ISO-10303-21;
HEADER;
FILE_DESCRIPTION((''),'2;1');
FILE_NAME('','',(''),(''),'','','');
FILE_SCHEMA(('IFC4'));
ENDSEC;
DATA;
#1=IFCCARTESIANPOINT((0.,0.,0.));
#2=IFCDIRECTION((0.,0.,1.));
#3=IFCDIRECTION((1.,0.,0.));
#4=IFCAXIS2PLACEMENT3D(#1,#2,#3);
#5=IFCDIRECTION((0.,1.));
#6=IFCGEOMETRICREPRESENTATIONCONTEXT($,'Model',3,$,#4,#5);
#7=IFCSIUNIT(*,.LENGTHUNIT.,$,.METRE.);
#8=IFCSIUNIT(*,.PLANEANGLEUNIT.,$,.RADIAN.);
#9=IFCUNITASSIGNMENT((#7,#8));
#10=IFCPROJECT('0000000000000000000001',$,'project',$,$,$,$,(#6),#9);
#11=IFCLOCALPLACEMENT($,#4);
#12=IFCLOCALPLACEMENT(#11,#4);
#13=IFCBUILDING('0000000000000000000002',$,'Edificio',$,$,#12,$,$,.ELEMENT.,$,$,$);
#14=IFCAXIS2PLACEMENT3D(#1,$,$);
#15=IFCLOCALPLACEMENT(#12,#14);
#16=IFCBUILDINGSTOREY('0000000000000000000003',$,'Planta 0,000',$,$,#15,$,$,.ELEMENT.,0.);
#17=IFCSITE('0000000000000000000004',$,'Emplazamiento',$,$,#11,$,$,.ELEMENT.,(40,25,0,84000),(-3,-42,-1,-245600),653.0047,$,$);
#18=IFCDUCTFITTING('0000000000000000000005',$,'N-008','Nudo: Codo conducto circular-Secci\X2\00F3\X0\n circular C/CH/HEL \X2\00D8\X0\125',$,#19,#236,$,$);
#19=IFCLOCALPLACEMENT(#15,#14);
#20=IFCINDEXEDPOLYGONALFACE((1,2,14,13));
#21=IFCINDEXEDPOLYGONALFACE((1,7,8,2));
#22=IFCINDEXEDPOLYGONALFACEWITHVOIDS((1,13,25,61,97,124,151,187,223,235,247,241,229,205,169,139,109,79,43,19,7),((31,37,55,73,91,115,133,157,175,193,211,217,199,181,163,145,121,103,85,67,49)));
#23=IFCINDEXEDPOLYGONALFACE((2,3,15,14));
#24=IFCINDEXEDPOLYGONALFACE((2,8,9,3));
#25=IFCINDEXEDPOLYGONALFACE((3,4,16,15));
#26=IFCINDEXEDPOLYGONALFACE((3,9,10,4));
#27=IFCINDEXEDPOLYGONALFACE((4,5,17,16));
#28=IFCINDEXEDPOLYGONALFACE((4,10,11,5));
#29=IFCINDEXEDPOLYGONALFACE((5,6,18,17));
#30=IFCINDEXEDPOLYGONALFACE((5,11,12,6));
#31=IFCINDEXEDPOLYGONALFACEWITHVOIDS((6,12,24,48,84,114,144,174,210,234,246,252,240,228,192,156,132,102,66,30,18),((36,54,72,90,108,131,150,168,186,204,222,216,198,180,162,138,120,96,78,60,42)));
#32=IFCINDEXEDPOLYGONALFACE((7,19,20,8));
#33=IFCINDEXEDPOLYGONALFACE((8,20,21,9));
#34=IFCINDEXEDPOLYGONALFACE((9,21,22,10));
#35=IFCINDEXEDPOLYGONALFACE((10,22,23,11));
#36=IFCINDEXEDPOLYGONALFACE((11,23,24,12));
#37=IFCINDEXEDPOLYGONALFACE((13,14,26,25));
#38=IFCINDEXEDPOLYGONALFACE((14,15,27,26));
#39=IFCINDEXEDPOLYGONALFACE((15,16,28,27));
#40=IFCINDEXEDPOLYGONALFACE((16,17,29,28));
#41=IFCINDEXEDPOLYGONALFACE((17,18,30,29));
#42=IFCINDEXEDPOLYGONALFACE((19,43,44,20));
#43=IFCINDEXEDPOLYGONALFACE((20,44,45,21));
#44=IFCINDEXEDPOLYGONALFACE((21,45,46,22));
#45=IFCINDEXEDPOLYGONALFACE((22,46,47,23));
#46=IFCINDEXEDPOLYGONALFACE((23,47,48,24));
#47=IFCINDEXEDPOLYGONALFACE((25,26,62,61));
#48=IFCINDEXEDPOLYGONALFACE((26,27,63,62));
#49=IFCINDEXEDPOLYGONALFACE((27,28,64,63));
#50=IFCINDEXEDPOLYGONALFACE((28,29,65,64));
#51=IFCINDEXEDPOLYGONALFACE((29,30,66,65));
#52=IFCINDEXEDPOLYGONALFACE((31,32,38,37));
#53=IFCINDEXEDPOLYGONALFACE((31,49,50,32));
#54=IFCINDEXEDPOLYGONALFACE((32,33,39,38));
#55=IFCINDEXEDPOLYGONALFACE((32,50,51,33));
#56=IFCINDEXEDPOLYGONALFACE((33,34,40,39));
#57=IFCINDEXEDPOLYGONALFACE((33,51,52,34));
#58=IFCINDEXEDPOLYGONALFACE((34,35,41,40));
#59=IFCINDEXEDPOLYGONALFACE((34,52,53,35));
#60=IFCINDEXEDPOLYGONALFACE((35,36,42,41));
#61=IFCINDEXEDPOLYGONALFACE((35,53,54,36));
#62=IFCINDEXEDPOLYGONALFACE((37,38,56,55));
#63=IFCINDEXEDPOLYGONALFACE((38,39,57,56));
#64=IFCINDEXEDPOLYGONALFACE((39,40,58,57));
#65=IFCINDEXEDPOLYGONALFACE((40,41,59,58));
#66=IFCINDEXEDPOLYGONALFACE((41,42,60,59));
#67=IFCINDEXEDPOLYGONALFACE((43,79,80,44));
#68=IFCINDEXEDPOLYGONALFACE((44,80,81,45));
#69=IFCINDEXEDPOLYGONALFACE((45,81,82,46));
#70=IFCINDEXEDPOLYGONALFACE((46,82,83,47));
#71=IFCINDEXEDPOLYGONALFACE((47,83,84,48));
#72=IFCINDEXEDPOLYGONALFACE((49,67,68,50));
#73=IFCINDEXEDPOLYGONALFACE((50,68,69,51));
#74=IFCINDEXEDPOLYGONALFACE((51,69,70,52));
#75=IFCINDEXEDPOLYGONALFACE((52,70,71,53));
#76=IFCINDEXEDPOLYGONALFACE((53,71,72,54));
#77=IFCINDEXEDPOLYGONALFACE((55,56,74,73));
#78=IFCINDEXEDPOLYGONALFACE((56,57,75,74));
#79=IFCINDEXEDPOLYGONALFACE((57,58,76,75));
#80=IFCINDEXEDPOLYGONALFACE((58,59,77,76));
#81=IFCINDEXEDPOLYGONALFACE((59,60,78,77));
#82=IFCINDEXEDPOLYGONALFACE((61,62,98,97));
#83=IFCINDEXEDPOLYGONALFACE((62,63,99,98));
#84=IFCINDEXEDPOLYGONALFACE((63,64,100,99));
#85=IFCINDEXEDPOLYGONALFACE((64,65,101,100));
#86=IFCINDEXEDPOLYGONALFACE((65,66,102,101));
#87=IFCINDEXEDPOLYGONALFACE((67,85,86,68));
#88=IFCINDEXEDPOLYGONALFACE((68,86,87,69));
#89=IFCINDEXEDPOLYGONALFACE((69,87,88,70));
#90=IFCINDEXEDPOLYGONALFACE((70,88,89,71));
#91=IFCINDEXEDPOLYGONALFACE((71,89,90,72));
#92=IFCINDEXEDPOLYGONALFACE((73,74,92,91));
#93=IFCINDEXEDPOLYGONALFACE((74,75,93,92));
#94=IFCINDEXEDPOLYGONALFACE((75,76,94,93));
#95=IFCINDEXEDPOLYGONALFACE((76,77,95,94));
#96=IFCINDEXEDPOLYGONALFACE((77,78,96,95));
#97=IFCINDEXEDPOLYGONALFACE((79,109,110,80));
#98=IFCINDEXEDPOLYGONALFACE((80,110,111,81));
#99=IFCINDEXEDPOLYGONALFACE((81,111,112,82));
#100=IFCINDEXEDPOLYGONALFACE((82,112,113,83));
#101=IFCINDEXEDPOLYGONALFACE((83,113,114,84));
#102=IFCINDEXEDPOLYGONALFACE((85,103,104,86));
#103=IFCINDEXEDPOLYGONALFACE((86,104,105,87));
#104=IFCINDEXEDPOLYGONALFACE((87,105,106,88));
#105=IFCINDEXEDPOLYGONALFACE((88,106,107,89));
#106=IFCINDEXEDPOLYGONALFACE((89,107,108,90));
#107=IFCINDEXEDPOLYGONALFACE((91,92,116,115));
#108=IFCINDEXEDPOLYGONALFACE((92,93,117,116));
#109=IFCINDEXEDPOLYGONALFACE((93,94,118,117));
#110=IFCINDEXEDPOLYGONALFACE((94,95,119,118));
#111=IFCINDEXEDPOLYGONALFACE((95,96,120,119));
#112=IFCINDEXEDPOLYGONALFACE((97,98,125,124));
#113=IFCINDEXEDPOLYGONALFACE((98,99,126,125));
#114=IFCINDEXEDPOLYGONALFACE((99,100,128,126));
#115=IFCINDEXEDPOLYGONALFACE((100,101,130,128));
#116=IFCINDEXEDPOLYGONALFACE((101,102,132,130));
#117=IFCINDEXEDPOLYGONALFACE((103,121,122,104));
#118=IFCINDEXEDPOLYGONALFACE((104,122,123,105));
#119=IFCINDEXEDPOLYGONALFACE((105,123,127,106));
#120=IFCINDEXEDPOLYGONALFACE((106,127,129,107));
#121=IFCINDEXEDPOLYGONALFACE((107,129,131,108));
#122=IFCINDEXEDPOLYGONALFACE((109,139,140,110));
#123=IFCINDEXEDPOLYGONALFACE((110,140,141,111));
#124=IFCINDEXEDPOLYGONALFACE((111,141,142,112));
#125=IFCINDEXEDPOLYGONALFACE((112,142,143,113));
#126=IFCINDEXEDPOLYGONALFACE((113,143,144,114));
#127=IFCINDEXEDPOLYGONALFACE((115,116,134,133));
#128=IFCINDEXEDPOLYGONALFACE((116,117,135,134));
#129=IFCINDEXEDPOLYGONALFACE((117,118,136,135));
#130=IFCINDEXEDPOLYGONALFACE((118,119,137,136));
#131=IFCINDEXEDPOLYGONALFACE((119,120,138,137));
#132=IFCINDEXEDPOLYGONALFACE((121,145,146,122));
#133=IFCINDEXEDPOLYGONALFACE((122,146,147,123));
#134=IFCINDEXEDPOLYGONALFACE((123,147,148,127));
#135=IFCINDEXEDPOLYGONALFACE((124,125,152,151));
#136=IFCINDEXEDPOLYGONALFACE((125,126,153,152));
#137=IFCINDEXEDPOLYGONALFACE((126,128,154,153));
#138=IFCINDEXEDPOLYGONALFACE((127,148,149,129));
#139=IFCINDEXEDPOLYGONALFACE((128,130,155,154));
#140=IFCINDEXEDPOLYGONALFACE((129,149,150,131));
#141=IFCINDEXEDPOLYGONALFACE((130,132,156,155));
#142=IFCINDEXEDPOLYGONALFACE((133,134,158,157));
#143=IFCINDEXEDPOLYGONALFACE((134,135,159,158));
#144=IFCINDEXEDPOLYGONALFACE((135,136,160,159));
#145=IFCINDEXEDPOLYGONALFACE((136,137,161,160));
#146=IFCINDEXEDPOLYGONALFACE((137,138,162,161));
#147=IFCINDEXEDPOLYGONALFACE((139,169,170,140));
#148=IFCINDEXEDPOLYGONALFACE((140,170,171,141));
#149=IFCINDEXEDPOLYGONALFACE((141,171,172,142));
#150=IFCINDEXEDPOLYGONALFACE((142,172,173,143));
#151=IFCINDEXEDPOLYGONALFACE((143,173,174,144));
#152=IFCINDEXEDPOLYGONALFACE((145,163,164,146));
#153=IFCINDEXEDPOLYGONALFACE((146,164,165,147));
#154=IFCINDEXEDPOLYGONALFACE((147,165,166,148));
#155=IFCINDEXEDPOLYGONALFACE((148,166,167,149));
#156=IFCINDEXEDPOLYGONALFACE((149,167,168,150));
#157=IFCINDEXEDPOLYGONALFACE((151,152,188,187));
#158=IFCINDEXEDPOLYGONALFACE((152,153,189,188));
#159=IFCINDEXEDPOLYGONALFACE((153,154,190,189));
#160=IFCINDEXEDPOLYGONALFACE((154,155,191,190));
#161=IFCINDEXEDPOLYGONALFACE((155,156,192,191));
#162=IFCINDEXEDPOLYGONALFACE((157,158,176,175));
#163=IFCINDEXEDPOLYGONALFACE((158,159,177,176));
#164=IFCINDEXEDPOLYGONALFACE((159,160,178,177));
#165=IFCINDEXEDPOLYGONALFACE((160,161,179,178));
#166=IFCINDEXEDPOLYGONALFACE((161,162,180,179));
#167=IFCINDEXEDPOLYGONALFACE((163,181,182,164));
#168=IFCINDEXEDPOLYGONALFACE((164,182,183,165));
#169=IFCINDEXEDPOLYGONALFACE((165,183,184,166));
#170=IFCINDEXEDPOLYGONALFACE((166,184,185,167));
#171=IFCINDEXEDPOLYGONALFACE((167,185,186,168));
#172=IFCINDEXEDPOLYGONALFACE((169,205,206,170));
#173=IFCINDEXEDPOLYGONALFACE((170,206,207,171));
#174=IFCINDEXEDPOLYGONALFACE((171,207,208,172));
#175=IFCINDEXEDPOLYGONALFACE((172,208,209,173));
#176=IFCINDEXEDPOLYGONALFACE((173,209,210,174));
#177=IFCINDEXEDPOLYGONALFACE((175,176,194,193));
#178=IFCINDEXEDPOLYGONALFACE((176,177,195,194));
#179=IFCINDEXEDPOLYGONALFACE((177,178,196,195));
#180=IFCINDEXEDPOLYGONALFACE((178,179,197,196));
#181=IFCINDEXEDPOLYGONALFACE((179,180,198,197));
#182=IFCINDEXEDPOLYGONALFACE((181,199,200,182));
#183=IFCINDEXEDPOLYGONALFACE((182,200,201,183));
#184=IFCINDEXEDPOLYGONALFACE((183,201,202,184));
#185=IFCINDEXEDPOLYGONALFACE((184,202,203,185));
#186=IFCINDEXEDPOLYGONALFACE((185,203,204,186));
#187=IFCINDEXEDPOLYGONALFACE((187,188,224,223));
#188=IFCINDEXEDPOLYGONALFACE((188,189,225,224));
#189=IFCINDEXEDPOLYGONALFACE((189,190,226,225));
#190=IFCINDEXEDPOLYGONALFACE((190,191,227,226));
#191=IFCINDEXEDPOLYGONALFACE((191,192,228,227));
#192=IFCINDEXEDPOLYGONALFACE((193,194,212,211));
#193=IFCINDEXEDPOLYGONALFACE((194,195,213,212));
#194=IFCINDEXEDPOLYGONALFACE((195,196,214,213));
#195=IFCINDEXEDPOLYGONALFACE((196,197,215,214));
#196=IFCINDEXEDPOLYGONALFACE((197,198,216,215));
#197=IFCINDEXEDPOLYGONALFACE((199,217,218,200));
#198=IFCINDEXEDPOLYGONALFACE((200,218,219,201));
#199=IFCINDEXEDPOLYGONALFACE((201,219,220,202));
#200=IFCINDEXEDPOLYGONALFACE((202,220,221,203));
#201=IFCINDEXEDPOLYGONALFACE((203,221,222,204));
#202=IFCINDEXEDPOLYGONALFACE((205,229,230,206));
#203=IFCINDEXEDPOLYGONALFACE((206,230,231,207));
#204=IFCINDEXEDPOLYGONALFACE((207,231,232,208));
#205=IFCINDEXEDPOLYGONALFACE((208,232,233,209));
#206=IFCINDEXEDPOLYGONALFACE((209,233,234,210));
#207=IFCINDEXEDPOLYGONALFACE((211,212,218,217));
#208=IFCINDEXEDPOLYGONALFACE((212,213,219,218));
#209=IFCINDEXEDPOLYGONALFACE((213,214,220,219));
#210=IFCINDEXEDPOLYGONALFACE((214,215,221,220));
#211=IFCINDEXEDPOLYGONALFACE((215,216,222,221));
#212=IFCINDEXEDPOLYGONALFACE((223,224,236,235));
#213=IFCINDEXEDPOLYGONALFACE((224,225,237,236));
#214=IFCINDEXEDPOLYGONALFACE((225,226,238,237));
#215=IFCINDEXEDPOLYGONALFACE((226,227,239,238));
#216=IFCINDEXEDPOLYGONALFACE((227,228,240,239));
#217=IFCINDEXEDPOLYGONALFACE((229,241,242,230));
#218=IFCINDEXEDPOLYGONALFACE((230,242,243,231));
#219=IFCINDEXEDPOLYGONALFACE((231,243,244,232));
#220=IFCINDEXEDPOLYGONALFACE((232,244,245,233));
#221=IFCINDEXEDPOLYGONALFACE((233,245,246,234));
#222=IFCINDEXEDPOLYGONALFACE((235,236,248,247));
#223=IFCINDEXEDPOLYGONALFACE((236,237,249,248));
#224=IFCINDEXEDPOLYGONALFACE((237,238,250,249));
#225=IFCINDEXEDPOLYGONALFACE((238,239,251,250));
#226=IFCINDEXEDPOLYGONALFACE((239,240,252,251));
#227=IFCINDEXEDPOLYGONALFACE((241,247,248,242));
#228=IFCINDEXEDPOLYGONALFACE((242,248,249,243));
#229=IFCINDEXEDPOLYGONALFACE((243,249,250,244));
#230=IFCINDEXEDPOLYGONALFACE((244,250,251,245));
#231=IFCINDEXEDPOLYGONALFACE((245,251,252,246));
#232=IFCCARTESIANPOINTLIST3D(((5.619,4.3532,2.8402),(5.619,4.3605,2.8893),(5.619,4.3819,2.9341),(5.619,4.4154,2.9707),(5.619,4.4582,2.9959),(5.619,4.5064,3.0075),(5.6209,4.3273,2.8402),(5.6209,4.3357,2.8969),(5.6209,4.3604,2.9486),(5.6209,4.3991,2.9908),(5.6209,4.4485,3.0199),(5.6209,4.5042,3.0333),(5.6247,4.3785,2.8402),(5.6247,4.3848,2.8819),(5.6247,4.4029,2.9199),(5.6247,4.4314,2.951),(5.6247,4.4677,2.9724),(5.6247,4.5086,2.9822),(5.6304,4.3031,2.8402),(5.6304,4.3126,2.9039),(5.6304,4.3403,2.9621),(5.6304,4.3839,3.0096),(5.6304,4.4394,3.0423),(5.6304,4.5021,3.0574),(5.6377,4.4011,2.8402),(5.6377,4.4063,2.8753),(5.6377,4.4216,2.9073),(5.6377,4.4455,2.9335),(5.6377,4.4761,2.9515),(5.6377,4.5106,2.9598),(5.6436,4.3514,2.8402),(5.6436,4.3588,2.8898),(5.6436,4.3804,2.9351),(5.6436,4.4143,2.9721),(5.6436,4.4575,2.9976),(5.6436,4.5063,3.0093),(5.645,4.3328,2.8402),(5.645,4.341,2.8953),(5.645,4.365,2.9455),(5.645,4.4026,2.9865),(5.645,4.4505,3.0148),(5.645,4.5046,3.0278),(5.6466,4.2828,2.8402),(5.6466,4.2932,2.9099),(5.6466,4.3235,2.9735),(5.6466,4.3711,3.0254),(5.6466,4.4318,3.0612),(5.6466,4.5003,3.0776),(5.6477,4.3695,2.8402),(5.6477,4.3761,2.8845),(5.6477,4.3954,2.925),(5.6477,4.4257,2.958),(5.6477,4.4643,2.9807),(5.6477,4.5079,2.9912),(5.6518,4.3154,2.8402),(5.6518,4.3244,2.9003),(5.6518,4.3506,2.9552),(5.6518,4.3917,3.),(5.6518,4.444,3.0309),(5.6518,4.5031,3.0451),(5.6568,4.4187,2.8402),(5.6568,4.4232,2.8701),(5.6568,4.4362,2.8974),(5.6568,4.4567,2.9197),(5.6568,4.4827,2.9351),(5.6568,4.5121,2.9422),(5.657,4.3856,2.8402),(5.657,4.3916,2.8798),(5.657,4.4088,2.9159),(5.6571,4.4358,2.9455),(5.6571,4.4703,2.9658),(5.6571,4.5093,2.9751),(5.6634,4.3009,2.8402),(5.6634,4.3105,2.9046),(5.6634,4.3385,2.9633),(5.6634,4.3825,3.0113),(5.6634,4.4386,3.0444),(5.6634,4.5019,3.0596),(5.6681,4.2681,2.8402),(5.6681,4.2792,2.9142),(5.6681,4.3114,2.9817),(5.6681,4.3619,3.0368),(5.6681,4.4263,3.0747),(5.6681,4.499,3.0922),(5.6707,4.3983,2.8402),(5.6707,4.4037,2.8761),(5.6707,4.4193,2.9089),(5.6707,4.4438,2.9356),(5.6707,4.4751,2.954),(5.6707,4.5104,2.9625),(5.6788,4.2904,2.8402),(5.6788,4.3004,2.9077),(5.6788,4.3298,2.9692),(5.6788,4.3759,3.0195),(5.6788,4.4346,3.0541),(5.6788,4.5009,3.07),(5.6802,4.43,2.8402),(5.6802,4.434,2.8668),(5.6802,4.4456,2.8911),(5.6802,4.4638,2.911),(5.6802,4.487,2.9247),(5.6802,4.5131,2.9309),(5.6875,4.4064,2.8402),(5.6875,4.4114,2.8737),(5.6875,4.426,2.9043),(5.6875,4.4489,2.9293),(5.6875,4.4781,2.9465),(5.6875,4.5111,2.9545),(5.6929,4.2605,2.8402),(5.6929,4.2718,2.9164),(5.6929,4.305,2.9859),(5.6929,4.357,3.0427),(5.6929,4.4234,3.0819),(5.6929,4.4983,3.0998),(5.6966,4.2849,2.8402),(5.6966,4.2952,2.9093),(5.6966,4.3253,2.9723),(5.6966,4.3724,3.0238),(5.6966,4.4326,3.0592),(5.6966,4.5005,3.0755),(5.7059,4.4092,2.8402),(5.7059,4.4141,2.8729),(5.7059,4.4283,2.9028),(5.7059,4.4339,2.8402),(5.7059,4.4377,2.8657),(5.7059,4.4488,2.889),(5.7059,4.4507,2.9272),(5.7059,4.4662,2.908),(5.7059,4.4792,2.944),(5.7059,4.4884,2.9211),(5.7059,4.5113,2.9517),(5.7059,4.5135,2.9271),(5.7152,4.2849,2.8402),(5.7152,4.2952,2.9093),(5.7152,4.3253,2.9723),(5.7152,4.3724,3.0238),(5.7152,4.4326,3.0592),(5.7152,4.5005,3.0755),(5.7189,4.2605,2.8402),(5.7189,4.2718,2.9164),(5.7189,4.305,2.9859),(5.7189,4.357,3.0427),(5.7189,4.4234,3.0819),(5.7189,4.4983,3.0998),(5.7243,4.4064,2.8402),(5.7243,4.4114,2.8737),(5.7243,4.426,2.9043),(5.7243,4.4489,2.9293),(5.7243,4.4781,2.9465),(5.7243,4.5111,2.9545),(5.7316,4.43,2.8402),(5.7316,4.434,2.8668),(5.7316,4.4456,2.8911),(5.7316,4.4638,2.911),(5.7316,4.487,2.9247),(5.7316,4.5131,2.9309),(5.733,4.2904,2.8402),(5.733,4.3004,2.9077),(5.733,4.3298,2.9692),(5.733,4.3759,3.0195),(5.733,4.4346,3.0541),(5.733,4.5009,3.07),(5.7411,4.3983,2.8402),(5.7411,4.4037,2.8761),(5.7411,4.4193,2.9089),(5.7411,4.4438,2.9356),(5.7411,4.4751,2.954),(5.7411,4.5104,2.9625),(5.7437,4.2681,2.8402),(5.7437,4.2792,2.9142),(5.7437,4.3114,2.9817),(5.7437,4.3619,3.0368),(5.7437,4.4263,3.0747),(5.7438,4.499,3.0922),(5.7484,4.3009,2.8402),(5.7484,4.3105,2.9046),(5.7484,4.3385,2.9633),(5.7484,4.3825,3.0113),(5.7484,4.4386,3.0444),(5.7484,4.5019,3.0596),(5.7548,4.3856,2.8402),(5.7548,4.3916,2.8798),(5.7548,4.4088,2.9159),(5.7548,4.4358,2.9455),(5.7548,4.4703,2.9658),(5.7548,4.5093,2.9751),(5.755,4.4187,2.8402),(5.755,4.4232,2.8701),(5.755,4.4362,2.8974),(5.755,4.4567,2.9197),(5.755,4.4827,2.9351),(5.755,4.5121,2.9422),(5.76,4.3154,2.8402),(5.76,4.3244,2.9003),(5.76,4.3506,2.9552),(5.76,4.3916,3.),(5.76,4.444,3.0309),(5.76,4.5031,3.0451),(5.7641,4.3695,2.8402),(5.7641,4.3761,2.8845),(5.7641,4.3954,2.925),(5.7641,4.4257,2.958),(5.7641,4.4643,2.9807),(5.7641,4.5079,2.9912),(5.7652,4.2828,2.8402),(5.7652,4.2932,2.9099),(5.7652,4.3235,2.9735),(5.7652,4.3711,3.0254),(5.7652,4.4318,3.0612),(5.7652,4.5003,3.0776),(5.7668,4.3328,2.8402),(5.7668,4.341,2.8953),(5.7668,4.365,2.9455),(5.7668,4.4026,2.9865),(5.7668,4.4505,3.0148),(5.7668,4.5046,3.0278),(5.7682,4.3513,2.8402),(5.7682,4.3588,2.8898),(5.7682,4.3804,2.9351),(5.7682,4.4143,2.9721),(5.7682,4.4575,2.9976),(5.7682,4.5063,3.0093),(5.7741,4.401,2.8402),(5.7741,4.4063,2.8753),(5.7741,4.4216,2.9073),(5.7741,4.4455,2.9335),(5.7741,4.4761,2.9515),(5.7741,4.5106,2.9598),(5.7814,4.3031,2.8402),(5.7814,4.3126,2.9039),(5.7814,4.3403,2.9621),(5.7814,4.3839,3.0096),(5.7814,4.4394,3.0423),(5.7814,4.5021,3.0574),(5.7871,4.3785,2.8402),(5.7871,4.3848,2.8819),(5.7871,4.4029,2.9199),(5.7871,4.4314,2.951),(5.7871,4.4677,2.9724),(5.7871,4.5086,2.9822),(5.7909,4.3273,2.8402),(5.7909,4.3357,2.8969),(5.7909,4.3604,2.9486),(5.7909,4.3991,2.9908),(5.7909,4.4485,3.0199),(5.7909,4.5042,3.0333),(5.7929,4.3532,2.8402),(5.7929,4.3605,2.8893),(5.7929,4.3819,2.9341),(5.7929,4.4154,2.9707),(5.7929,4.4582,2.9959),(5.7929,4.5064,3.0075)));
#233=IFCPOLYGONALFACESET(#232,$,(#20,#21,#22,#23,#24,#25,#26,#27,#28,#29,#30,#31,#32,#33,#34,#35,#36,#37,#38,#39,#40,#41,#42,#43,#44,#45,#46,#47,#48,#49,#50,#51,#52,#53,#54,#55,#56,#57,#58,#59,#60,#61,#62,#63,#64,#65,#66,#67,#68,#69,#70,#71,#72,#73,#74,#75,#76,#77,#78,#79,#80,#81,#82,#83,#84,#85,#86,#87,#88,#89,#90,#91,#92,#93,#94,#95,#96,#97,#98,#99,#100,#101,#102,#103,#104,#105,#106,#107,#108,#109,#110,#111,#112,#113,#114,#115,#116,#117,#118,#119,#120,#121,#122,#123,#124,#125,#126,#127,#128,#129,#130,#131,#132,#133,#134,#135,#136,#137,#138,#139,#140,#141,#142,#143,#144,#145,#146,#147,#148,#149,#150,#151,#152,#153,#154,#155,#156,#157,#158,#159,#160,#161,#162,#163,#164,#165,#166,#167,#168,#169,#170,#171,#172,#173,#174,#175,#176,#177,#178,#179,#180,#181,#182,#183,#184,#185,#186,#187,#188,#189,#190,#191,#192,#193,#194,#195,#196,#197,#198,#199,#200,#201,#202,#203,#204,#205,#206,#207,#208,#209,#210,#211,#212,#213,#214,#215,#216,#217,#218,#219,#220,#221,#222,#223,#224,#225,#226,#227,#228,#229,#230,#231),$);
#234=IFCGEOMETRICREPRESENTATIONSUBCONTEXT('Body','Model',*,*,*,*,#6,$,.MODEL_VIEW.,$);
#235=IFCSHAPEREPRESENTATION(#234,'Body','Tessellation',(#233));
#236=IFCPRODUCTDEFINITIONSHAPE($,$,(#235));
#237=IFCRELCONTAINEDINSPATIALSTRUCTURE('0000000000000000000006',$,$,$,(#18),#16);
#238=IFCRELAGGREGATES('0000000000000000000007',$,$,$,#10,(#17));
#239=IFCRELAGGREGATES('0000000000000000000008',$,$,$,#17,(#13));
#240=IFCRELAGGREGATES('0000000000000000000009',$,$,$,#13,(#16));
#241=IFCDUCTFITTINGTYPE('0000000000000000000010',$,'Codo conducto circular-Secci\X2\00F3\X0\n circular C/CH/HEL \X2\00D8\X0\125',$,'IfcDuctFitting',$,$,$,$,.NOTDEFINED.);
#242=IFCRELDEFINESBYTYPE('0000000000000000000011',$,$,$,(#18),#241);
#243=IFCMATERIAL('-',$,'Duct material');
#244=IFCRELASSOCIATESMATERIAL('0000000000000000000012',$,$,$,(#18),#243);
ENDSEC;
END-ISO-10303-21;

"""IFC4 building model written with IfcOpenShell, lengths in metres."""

from ifc_helpers import new_model, entity, si_unit, direction, origin, origin_with_axes, place, context, subcontext, project, spatial, source, transform, mapped, material, type_object, element, save


model = new_model("IFC4")

# Units and contexts
model_context = context("Model", 3, world=origin_with_axes(), true_north=direction((0.0, 1.0)))
body_context = subcontext(model_context, "Body", "Model", "MODEL_VIEW")
ifc_project = project(units=[si_unit("LENGTHUNIT", "METRE"), si_unit("PLANEANGLEUNIT", "RADIAN")], contexts=[model_context])

# Site, building, storey
site_placement = place(None, origin_with_axes())
site = spatial("IfcSite", under=ifc_project, at=site_placement, Name="Emplazamiento", CompositionType="ELEMENT", RefLatitude=(40, 25, 0, 84000), RefLongitude=(-3, -42, -1, -245600), RefElevation=653.0047)
building_placement = place(site_placement, origin_with_axes())
building = spatial("IfcBuilding", under=site, at=building_placement, Name="Edificio", CompositionType="ELEMENT")
storey_placement = place(building_placement, origin())
storey = spatial("IfcBuildingStorey", under=building, at=storey_placement, Name="Planta 0,000", CompositionType="ELEMENT", Elevation=0.0)

# Shared definitions
ifc_material_1 = material(Name="-", Category="Duct material")
duct_fitting_type_1 = type_object("IfcDuctFittingType", Name="Codo conducto circular-Sección circular C/CH/HEL Ø125", ApplicableOccurrence="IfcDuctFitting", PredefinedType="NOTDEFINED")

# Duct fitting
shared_shape_1 = source(origin_with_axes(), body_context, "Body", "SweptSolid", [
    entity("IfcRevolvedAreaSolid", entity("IfcCircleHollowProfileDef", "AREA", None, entity("IfcAxis2Placement2D", entity("IfcCartesianPoint", [0.0, 0.0]), entity("IfcDirection", [1.0, 0.0])), 0.0872, 0.0247), entity("IfcAxis2Placement3D", entity("IfcCartesianPoint", [0.1592, 0.0139, 0.0]), entity("IfcDirection", [-0.996184, -0.087276, 0.0]), entity("IfcDirection", [0.087276, -0.996184, 0.0])), entity("IfcAxis1Placement", entity("IfcCartesianPoint", [0.1744, 0.0, 0.0]), entity("IfcDirection", [0.0, 1.0, 0.0])), 1.483409),
])
duct_fitting_1_placement = place(storey_placement, origin_with_axes())
element("IfcDuctFitting", 1, at=duct_fitting_1_placement, inside=storey, type_object=duct_fitting_type_1, material=ifc_material_1, Name="N-008", Description="Nudo: Codo conducto circular-Sección circular C/CH/HEL Ø125", context=body_context, shape_type="MappedRepresentation", body=[
    mapped(shared_shape_1, transform((5.7059, 4.3467, 3.0), x_axis=(0.000002, 0.087276, -0.996184), y_axis=(-0.000024, -0.996184, -0.087276), z_axis=(-1.0, 0.000024, 0.0), scale=1.0)),
])

save(model, "model.ifc")
